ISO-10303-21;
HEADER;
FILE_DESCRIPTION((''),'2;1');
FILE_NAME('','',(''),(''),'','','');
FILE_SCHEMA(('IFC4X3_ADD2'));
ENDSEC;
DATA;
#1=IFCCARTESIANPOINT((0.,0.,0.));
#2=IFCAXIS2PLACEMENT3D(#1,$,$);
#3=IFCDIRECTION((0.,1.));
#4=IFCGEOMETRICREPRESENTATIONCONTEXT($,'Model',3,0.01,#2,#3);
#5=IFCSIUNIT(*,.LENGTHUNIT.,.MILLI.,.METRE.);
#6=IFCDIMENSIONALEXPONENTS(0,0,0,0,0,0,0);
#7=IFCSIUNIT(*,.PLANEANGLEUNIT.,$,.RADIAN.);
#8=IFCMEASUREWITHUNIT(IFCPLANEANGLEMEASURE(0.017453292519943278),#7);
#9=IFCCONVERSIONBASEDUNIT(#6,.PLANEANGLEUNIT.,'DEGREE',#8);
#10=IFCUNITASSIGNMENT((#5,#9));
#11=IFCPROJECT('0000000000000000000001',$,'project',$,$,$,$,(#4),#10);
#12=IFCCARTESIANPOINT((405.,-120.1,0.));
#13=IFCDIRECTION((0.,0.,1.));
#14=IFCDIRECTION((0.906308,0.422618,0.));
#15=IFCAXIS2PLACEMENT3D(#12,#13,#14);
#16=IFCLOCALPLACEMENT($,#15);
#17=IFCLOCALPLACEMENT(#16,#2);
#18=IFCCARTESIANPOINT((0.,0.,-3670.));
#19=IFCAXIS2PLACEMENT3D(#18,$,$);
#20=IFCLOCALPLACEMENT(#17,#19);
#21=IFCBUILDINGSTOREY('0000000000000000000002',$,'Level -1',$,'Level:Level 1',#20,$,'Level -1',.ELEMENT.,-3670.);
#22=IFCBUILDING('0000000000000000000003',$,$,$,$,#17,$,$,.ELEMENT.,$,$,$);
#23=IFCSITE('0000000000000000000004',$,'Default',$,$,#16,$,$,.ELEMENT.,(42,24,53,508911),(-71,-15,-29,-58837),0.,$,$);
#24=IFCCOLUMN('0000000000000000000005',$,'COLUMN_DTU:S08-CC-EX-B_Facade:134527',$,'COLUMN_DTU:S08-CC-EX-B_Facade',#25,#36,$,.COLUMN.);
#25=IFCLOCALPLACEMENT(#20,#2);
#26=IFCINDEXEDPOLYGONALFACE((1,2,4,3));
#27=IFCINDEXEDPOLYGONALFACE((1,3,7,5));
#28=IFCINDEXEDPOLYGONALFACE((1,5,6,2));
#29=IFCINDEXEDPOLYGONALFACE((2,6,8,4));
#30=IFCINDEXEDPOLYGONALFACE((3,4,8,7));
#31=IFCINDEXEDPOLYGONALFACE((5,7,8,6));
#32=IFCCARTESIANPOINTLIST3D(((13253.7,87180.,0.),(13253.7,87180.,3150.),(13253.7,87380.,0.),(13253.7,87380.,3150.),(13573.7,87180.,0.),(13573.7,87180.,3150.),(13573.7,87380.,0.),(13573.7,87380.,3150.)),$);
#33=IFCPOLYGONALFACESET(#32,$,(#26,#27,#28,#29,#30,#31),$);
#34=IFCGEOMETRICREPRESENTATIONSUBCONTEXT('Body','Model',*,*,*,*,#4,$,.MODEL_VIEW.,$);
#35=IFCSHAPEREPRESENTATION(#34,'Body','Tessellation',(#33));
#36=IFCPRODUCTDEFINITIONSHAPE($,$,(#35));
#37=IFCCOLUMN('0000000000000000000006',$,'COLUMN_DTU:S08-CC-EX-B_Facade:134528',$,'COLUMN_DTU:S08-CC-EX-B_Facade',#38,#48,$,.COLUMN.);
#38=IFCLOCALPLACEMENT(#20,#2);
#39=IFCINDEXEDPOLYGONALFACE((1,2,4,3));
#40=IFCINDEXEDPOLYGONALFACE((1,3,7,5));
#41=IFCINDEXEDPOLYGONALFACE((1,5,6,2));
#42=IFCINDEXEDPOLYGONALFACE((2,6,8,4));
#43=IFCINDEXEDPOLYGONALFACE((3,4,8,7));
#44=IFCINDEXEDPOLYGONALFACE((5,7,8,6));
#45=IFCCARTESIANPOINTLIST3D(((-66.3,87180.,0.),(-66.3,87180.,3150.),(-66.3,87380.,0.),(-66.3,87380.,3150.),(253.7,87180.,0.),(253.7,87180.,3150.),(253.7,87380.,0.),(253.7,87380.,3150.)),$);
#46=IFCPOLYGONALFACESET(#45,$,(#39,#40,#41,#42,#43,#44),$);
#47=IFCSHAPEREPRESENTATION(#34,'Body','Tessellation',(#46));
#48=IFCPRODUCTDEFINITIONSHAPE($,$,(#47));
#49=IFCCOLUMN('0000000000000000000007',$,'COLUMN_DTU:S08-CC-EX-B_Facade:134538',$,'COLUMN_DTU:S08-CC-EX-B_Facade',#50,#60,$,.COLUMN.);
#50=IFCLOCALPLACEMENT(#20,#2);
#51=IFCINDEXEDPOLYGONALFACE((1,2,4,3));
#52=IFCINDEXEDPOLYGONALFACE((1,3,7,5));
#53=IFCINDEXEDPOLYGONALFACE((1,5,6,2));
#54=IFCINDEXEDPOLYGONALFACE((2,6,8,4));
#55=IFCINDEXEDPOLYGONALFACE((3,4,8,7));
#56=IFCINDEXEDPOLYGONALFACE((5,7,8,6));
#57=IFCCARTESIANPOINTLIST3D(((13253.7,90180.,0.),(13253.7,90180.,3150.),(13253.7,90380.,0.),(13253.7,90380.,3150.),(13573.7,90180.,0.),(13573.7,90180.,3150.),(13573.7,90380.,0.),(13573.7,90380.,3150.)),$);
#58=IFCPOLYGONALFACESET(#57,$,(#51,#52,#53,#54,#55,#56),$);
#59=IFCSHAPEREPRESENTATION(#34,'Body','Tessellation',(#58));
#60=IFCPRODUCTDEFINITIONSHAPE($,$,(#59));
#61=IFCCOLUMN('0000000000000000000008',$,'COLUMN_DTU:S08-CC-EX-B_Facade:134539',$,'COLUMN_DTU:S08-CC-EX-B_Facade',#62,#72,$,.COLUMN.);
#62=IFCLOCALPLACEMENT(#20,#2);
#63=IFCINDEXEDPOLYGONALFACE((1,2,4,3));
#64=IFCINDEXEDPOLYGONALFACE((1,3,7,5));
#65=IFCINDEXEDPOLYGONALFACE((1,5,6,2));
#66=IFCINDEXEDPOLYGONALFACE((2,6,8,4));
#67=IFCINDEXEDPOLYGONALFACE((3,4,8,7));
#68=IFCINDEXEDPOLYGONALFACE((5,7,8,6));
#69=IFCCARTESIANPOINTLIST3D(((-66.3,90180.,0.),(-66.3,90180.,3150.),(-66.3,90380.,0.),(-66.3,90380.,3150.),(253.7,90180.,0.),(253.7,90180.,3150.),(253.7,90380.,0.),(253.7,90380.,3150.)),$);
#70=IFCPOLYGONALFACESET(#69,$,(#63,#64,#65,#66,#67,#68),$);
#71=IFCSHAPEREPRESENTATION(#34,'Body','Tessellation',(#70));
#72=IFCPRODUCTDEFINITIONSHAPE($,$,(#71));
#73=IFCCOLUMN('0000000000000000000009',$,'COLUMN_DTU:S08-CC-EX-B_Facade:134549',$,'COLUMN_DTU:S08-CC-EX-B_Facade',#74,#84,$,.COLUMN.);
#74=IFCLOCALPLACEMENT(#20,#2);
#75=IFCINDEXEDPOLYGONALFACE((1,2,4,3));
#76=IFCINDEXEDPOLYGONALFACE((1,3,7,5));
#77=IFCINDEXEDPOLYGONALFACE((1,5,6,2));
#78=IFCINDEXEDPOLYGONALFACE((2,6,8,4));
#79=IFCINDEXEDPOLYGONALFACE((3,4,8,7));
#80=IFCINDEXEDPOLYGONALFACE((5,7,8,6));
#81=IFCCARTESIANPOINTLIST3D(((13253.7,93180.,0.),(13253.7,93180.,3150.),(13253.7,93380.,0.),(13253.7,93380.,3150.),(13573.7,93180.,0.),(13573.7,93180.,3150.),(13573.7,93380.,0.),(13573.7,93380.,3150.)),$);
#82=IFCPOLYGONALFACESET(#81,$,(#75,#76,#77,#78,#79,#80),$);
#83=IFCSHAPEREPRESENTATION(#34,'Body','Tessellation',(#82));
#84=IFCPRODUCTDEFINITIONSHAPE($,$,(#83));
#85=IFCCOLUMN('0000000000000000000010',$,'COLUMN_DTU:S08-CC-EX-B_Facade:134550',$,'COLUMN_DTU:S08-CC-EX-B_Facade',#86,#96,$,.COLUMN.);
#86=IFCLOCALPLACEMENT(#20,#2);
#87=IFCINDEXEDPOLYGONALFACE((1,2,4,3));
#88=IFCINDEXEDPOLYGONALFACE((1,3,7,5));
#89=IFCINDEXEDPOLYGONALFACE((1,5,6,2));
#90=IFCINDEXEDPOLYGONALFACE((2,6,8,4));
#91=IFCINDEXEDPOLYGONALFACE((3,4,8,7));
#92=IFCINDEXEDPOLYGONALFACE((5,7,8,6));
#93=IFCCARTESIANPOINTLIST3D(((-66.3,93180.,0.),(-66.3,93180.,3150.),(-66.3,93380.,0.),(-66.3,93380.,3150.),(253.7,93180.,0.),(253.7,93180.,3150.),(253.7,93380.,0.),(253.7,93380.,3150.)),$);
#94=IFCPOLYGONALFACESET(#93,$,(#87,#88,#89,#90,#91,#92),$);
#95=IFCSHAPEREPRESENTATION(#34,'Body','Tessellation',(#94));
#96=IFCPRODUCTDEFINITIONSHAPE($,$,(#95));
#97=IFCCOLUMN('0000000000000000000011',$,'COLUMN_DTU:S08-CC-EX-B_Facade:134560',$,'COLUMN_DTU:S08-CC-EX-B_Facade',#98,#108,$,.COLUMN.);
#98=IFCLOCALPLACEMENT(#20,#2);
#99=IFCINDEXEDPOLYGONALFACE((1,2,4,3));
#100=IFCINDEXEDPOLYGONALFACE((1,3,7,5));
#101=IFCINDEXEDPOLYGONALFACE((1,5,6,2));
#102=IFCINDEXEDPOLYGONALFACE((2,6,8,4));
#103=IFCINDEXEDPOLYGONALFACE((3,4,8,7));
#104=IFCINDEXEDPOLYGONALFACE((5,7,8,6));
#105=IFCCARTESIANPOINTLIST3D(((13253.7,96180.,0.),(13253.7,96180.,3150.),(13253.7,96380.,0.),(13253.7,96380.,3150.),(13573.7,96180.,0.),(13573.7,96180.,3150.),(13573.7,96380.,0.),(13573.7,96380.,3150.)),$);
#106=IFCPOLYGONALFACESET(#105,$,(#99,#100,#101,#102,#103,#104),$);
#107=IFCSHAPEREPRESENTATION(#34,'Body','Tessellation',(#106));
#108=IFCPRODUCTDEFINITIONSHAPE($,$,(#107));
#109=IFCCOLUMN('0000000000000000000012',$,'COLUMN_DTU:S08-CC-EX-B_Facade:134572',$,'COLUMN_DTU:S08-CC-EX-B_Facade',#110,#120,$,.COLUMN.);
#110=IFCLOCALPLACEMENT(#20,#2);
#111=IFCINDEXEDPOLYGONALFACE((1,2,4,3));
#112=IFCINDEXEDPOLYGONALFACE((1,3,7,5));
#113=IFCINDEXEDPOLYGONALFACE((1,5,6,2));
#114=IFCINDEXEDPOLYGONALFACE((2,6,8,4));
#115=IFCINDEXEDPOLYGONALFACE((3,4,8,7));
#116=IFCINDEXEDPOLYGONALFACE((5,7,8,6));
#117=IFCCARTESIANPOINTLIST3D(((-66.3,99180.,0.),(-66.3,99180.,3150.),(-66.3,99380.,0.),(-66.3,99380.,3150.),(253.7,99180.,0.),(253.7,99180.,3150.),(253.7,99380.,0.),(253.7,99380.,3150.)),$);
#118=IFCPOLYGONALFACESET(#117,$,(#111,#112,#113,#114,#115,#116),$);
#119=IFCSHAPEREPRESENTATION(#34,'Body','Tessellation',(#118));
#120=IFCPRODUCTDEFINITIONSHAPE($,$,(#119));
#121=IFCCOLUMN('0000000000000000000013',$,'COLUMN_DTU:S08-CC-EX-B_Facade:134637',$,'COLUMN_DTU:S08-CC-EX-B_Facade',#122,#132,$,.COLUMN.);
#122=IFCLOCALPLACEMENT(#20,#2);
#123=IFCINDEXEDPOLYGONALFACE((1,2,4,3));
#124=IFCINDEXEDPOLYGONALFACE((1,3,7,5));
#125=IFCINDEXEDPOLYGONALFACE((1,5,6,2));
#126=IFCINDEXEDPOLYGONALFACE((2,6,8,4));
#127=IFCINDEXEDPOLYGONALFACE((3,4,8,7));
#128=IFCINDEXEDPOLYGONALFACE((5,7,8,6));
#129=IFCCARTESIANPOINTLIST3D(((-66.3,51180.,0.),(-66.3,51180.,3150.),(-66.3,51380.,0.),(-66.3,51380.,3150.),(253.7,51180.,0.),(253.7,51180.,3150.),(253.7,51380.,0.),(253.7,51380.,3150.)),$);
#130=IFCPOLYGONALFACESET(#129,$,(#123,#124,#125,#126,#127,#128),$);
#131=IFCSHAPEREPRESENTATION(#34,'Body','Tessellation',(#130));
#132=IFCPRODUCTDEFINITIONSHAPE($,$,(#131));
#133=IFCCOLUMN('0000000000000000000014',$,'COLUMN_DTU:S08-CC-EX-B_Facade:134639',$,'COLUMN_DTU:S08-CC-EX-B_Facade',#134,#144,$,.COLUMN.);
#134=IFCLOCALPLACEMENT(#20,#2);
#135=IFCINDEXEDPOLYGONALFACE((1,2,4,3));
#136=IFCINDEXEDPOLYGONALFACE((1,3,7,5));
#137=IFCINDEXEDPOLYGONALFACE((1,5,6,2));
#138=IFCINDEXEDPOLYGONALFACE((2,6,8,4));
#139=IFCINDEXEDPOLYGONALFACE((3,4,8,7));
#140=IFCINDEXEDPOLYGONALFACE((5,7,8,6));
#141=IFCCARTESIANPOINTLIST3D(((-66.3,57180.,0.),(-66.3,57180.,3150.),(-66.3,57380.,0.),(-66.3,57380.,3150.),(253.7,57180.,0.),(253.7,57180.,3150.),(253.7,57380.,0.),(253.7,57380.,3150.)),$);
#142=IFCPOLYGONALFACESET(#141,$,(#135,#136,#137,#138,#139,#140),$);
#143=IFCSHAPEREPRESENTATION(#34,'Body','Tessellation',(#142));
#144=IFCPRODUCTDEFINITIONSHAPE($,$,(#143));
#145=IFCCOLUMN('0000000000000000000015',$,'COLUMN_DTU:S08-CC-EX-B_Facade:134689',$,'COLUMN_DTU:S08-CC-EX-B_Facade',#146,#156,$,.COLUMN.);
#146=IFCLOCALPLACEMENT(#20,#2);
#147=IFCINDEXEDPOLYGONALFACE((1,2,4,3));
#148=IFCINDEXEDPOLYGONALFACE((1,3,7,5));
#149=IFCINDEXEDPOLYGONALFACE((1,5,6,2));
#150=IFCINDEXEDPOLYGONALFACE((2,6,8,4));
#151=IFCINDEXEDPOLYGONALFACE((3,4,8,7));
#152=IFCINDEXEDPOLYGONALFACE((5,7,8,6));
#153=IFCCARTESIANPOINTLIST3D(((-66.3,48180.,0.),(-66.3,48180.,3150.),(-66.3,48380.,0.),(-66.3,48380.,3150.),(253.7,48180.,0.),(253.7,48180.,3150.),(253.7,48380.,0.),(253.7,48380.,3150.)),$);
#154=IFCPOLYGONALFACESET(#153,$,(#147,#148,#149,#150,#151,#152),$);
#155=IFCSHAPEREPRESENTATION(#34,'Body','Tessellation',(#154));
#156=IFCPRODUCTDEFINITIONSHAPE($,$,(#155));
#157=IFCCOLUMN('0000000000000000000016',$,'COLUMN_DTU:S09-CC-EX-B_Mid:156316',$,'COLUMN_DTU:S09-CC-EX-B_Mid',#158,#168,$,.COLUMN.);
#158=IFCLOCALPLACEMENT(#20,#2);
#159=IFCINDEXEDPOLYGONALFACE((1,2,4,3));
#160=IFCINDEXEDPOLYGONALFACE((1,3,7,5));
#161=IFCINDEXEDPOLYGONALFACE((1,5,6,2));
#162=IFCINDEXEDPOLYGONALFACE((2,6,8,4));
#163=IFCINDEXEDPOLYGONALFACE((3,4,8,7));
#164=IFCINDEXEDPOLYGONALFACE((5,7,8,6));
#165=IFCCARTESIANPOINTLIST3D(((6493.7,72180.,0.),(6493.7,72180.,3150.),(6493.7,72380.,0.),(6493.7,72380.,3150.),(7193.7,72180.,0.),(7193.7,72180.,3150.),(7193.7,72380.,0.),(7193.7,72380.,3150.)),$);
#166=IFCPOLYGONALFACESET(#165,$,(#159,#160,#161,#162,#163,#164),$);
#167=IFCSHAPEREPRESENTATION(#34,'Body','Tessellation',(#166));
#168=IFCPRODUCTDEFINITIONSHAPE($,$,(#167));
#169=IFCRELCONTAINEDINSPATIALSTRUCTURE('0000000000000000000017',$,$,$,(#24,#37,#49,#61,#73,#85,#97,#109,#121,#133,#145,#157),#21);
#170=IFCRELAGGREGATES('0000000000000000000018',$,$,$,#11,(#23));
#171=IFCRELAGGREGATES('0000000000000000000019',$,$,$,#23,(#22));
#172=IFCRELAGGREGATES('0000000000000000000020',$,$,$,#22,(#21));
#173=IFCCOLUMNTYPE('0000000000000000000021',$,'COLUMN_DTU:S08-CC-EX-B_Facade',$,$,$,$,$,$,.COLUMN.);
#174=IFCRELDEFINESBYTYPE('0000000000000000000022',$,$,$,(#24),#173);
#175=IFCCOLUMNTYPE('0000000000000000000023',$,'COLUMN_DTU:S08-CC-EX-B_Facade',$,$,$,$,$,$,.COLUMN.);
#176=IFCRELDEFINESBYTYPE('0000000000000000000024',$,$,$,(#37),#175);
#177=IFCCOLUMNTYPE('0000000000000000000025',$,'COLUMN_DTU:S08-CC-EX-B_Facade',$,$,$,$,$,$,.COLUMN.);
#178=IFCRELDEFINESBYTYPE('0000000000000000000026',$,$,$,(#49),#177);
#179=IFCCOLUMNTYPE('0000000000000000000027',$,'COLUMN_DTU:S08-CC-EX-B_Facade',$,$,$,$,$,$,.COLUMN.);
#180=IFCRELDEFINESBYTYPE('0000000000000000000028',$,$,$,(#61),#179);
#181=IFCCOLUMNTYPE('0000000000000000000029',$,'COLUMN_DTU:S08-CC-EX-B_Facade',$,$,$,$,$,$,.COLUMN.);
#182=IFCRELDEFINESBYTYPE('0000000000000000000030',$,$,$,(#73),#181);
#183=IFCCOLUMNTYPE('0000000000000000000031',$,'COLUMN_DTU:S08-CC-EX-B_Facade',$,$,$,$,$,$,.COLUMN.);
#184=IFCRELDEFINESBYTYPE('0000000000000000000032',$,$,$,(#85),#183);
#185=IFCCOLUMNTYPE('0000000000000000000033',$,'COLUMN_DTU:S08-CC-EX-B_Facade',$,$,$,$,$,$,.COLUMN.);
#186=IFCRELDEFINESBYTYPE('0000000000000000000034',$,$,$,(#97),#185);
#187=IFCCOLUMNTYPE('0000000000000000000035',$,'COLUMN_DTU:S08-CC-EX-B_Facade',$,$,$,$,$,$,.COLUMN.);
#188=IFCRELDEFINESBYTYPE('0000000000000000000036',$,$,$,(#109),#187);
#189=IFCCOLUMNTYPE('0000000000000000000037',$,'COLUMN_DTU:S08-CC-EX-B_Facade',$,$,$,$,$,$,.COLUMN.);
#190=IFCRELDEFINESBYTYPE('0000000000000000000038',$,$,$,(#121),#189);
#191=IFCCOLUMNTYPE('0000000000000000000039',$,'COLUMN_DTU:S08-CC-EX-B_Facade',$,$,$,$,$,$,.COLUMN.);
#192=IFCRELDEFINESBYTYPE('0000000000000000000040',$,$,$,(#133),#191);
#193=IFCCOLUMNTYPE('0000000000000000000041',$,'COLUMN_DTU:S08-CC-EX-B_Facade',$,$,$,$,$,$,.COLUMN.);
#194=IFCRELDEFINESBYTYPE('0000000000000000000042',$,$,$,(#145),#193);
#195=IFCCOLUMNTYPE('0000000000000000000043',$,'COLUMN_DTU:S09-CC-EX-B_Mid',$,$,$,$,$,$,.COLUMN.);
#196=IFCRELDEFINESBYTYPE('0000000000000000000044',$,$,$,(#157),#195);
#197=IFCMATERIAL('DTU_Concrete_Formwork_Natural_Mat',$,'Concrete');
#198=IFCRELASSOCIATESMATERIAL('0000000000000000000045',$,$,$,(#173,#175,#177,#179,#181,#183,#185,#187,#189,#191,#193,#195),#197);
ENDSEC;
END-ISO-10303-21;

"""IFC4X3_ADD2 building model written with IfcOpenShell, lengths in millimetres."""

from ifc_helpers import new_model, entity, si_unit, converted_unit, direction, frame, frame_2d, origin, origin_2d_with_axis, place, context, subcontext, project, spatial, rectangle, extrude, source, transform, mapped, material, material_profile, profile_set, type_object, type_shapes, element, save


model = new_model("IFC4X3_ADD2")

# Units and contexts
model_context = context("Model", 3, precision=0.01, world=origin(), true_north=direction((0.0, 1.0)))
body_context = subcontext(model_context, "Body", "Model", "MODEL_VIEW")
ifc_project = project(units=[si_unit("LENGTHUNIT", "METRE", prefix="MILLI"), converted_unit("PLANEANGLEUNIT", "DEGREE", entity("IfcPlaneAngleMeasure", 0.017453292519943278), si_unit("PLANEANGLEUNIT", "RADIAN"), dimensions=[0, 0, 0, 0, 0, 0, 0])], contexts=[model_context])

# Site, building, storey
site_placement = place(None, frame((405.0, -120.1, 0.0), z_axis=(0.0, 0.0, 1.0), x_axis=(0.906308, 0.422618, 0.0)))
site = spatial("IfcSite", under=ifc_project, at=site_placement, Name="Default", CompositionType="ELEMENT", RefLatitude=(42, 24, 53, 508911), RefLongitude=(-71, -15, -29, -58837), RefElevation=0.0)
building_placement = place(site_placement, origin())
building = spatial("IfcBuilding", under=site, at=building_placement, CompositionType="ELEMENT")
storey_placement = place(building_placement, frame((0.0, 0.0, -3670.0)))
storey = spatial("IfcBuildingStorey", under=building, at=storey_placement, Name="Level -1", ObjectType="Level:Level 1", LongName="Level -1", CompositionType="ELEMENT", Elevation=-3670.0)

# Columns
ifc_material = material(Name="DTU_Concrete_Formwork_Natural_Mat", Category="Concrete")
ifc_material_profile_1 = material_profile(ifc_material, rectangle(XDim=200.0, YDim=700.0, at=frame_2d((0.0, 0.0), x_axis=(1.0, 0.0))), Name="S09-CC-EX-B_Mid")
ifc_profile_set_1 = profile_set([ifc_material_profile_1], Name="S09-CC-EX-B_Mid")
ifc_material_profile_2 = material_profile(ifc_material, rectangle(XDim=200.0, YDim=320.0, at=origin_2d_with_axis()), Name="S08-CC-EX-B_Facade")
ifc_profile_set_2 = profile_set([ifc_material_profile_2], Name="S08-CC-EX-B_Facade")
column_type_1 = type_object("IfcColumnType", Name="COLUMN_DTU:S08-CC-EX-B_Facade", PredefinedType="COLUMN", material=ifc_profile_set_2)
shared_shape_1 = source(origin(), body_context, "Body", "SweptSolid", [
    extrude(rectangle(XDim=200.0, YDim=320.0, at=frame_2d((0.0, 0.0), x_axis=(1.0, 0.0))), frame((13413.7, 87280.0, -3670.0), z_axis=(0.0, 0.0, 1.0), x_axis=(0.0, -1.0, 0.0)), (0.0, 0.0, 1.0), 3150.0),
])
type_shapes(column_type_1, [shared_shape_1])
column_1_placement = place(storey_placement, frame((0.0, 0.0, 3670.0)))
element("IfcColumn", 1, at=column_1_placement, inside=storey, type_object=column_type_1, Name="COLUMN_DTU:S08-CC-EX-B_Facade:134527", ObjectType="COLUMN_DTU:S08-CC-EX-B_Facade", PredefinedType="COLUMN", context=body_context, shape_type="MappedRepresentation", body=[
    mapped(shared_shape_1, transform((0.0, 0.0, 0.0), scale=1.0)),
])
column_type_2 = type_object("IfcColumnType", Name="COLUMN_DTU:S08-CC-EX-B_Facade", PredefinedType="COLUMN", material=ifc_profile_set_2)
shared_shape_2 = source(origin(), body_context, "Body", "SweptSolid", [
    extrude(rectangle(XDim=200.0, YDim=320.0, at=frame_2d((0.0, 0.0), x_axis=(1.0, 0.0))), frame((93.7, 87280.0, -3670.0), z_axis=(0.0, 0.0, 1.0), x_axis=(0.0, -1.0, 0.0)), (0.0, 0.0, 1.0), 3150.0),
])
type_shapes(column_type_2, [shared_shape_2])
column_2_placement = place(storey_placement, frame((0.0, 0.0, 3670.0)))
element("IfcColumn", 2, at=column_2_placement, inside=storey, type_object=column_type_2, Name="COLUMN_DTU:S08-CC-EX-B_Facade:134528", ObjectType="COLUMN_DTU:S08-CC-EX-B_Facade", PredefinedType="COLUMN", context=body_context, shape_type="MappedRepresentation", body=[
    mapped(shared_shape_2, transform((0.0, 0.0, 0.0), scale=1.0)),
])
column_type_3 = type_object("IfcColumnType", Name="COLUMN_DTU:S08-CC-EX-B_Facade", PredefinedType="COLUMN", material=ifc_profile_set_2)
shared_shape_3 = source(origin(), body_context, "Body", "SweptSolid", [
    extrude(rectangle(XDim=200.0, YDim=320.0, at=frame_2d((0.0, 0.0), x_axis=(1.0, 0.0))), frame((13413.7, 90280.0, -3670.0), z_axis=(0.0, 0.0, 1.0), x_axis=(0.0, -1.0, 0.0)), (0.0, 0.0, 1.0), 3150.0),
])
type_shapes(column_type_3, [shared_shape_3])
column_3_placement = place(storey_placement, frame((0.0, 0.0, 3670.0)))
element("IfcColumn", 3, at=column_3_placement, inside=storey, type_object=column_type_3, Name="COLUMN_DTU:S08-CC-EX-B_Facade:134538", ObjectType="COLUMN_DTU:S08-CC-EX-B_Facade", PredefinedType="COLUMN", context=body_context, shape_type="MappedRepresentation", body=[
    mapped(shared_shape_3, transform((0.0, 0.0, 0.0), scale=1.0)),
])
column_type_4 = type_object("IfcColumnType", Name="COLUMN_DTU:S08-CC-EX-B_Facade", PredefinedType="COLUMN", material=ifc_profile_set_2)
shared_shape_4 = source(origin(), body_context, "Body", "SweptSolid", [
    extrude(rectangle(XDim=200.0, YDim=320.0, at=frame_2d((0.0, 0.0), x_axis=(1.0, 0.0))), frame((93.7, 90280.0, -3670.0), z_axis=(0.0, 0.0, 1.0), x_axis=(0.0, -1.0, 0.0)), (0.0, 0.0, 1.0), 3150.0),
])
type_shapes(column_type_4, [shared_shape_4])
column_4_placement = place(storey_placement, frame((0.0, 0.0, 3670.0)))
element("IfcColumn", 4, at=column_4_placement, inside=storey, type_object=column_type_4, Name="COLUMN_DTU:S08-CC-EX-B_Facade:134539", ObjectType="COLUMN_DTU:S08-CC-EX-B_Facade", PredefinedType="COLUMN", context=body_context, shape_type="MappedRepresentation", body=[
    mapped(shared_shape_4, transform((0.0, 0.0, 0.0), scale=1.0)),
])
column_type_5 = type_object("IfcColumnType", Name="COLUMN_DTU:S08-CC-EX-B_Facade", PredefinedType="COLUMN", material=ifc_profile_set_2)
shared_shape_5 = source(origin(), body_context, "Body", "SweptSolid", [
    extrude(rectangle(XDim=200.0, YDim=320.0, at=frame_2d((0.0, 0.0), x_axis=(1.0, 0.0))), frame((13413.7, 93280.0, -3670.0), z_axis=(0.0, 0.0, 1.0), x_axis=(0.0, -1.0, 0.0)), (0.0, 0.0, 1.0), 3150.0),
])
type_shapes(column_type_5, [shared_shape_5])
column_5_placement = place(storey_placement, frame((0.0, 0.0, 3670.0)))
element("IfcColumn", 5, at=column_5_placement, inside=storey, type_object=column_type_5, Name="COLUMN_DTU:S08-CC-EX-B_Facade:134549", ObjectType="COLUMN_DTU:S08-CC-EX-B_Facade", PredefinedType="COLUMN", context=body_context, shape_type="MappedRepresentation", body=[
    mapped(shared_shape_5, transform((0.0, 0.0, 0.0), scale=1.0)),
])
column_type_6 = type_object("IfcColumnType", Name="COLUMN_DTU:S08-CC-EX-B_Facade", PredefinedType="COLUMN", material=ifc_profile_set_2)
shared_shape_6 = source(origin(), body_context, "Body", "SweptSolid", [
    extrude(rectangle(XDim=200.0, YDim=320.0, at=frame_2d((0.0, 0.0), x_axis=(1.0, 0.0))), frame((93.7, 93280.0, -3670.0), z_axis=(0.0, 0.0, 1.0), x_axis=(0.0, -1.0, 0.0)), (0.0, 0.0, 1.0), 3150.0),
])
type_shapes(column_type_6, [shared_shape_6])
column_6_placement = place(storey_placement, frame((0.0, 0.0, 3670.0)))
element("IfcColumn", 6, at=column_6_placement, inside=storey, type_object=column_type_6, Name="COLUMN_DTU:S08-CC-EX-B_Facade:134550", ObjectType="COLUMN_DTU:S08-CC-EX-B_Facade", PredefinedType="COLUMN", context=body_context, shape_type="MappedRepresentation", body=[
    mapped(shared_shape_6, transform((0.0, 0.0, 0.0), scale=1.0)),
])
column_type_7 = type_object("IfcColumnType", Name="COLUMN_DTU:S08-CC-EX-B_Facade", PredefinedType="COLUMN", material=ifc_profile_set_2)
shared_shape_7 = source(origin(), body_context, "Body", "SweptSolid", [
    extrude(rectangle(XDim=200.0, YDim=320.0, at=frame_2d((0.0, 0.0), x_axis=(1.0, 0.0))), frame((13413.7, 96280.0, -3670.0), z_axis=(0.0, 0.0, 1.0), x_axis=(0.0, -1.0, 0.0)), (0.0, 0.0, 1.0), 3150.0),
])
type_shapes(column_type_7, [shared_shape_7])
column_7_placement = place(storey_placement, frame((0.0, 0.0, 3670.0)))
element("IfcColumn", 7, at=column_7_placement, inside=storey, type_object=column_type_7, Name="COLUMN_DTU:S08-CC-EX-B_Facade:134560", ObjectType="COLUMN_DTU:S08-CC-EX-B_Facade", PredefinedType="COLUMN", context=body_context, shape_type="MappedRepresentation", body=[
    mapped(shared_shape_7, transform((0.0, 0.0, 0.0), scale=1.0)),
])
column_type_8 = type_object("IfcColumnType", Name="COLUMN_DTU:S08-CC-EX-B_Facade", PredefinedType="COLUMN", material=ifc_profile_set_2)
shared_shape_8 = source(origin(), body_context, "Body", "SweptSolid", [
    extrude(rectangle(XDim=200.0, YDim=320.0, at=frame_2d((0.0, 0.0), x_axis=(1.0, 0.0))), frame((93.7, 99280.0, -3670.0), z_axis=(0.0, 0.0, 1.0), x_axis=(0.0, -1.0, 0.0)), (0.0, 0.0, 1.0), 3150.0),
])
type_shapes(column_type_8, [shared_shape_8])
column_8_placement = place(storey_placement, frame((0.0, 0.0, 3670.0)))
element("IfcColumn", 8, at=column_8_placement, inside=storey, type_object=column_type_8, Name="COLUMN_DTU:S08-CC-EX-B_Facade:134572", ObjectType="COLUMN_DTU:S08-CC-EX-B_Facade", PredefinedType="COLUMN", context=body_context, shape_type="MappedRepresentation", body=[
    mapped(shared_shape_8, transform((0.0, 0.0, 0.0), scale=1.0)),
])
column_type_9 = type_object("IfcColumnType", Name="COLUMN_DTU:S08-CC-EX-B_Facade", PredefinedType="COLUMN", material=ifc_profile_set_2)
shared_shape_9 = source(origin(), body_context, "Body", "SweptSolid", [
    extrude(rectangle(XDim=200.0, YDim=320.0, at=frame_2d((0.0, 0.0), x_axis=(1.0, 0.0))), frame((93.7, 51280.0, -3670.0), z_axis=(0.0, 0.0, 1.0), x_axis=(0.0, -1.0, 0.0)), (0.0, 0.0, 1.0), 3150.0),
])
type_shapes(column_type_9, [shared_shape_9])
column_9_placement = place(storey_placement, frame((0.0, 0.0, 3670.0)))
element("IfcColumn", 9, at=column_9_placement, inside=storey, type_object=column_type_9, Name="COLUMN_DTU:S08-CC-EX-B_Facade:134637", ObjectType="COLUMN_DTU:S08-CC-EX-B_Facade", PredefinedType="COLUMN", context=body_context, shape_type="MappedRepresentation", body=[
    mapped(shared_shape_9, transform((0.0, 0.0, 0.0), scale=1.0)),
])
column_type_10 = type_object("IfcColumnType", Name="COLUMN_DTU:S08-CC-EX-B_Facade", PredefinedType="COLUMN", material=ifc_profile_set_2)
shared_shape_10 = source(origin(), body_context, "Body", "SweptSolid", [
    extrude(rectangle(XDim=200.0, YDim=320.0, at=frame_2d((0.0, 0.0), x_axis=(1.0, 0.0))), frame((93.7, 57280.0, -3670.0), z_axis=(0.0, 0.0, 1.0), x_axis=(0.0, -1.0, 0.0)), (0.0, 0.0, 1.0), 3150.0),
])
type_shapes(column_type_10, [shared_shape_10])
column_10_placement = place(storey_placement, frame((0.0, 0.0, 3670.0)))
element("IfcColumn", 10, at=column_10_placement, inside=storey, type_object=column_type_10, Name="COLUMN_DTU:S08-CC-EX-B_Facade:134639", ObjectType="COLUMN_DTU:S08-CC-EX-B_Facade", PredefinedType="COLUMN", context=body_context, shape_type="MappedRepresentation", body=[
    mapped(shared_shape_10, transform((0.0, 0.0, 0.0), scale=1.0)),
])
column_type_11 = type_object("IfcColumnType", Name="COLUMN_DTU:S08-CC-EX-B_Facade", PredefinedType="COLUMN", material=ifc_profile_set_2)
shared_shape_11 = source(origin(), body_context, "Body", "SweptSolid", [
    extrude(rectangle(XDim=200.0, YDim=320.0, at=frame_2d((0.0, 0.0), x_axis=(1.0, 0.0))), frame((93.7, 48280.0, -3670.0), z_axis=(0.0, 0.0, 1.0), x_axis=(0.0, -1.0, 0.0)), (0.0, 0.0, 1.0), 3150.0),
])
type_shapes(column_type_11, [shared_shape_11])
column_11_placement = place(storey_placement, frame((0.0, 0.0, 3670.0)))
element("IfcColumn", 11, at=column_11_placement, inside=storey, type_object=column_type_11, Name="COLUMN_DTU:S08-CC-EX-B_Facade:134689", ObjectType="COLUMN_DTU:S08-CC-EX-B_Facade", PredefinedType="COLUMN", context=body_context, shape_type="MappedRepresentation", body=[
    mapped(shared_shape_11, transform((0.0, 0.0, 0.0), scale=1.0)),
])
column_type_12 = type_object("IfcColumnType", Name="COLUMN_DTU:S09-CC-EX-B_Mid", PredefinedType="COLUMN", material=ifc_profile_set_1)
shared_shape_12 = source(origin(), body_context, "Body", "SweptSolid", [
    extrude(rectangle(XDim=200.0, YDim=700.0, at=frame_2d((0.0, 0.0), x_axis=(1.0, 0.0))), frame((6843.7, 72280.0, -3670.0), z_axis=(0.0, 0.0, 1.0), x_axis=(0.0, 1.0, 0.0)), (0.0, 0.0, 1.0), 3150.0),
])
type_shapes(column_type_12, [shared_shape_12])
column_12_placement = place(storey_placement, frame((0.0, 0.0, 3670.0)))
element("IfcColumn", 12, at=column_12_placement, inside=storey, type_object=column_type_12, Name="COLUMN_DTU:S09-CC-EX-B_Mid:156316", ObjectType="COLUMN_DTU:S09-CC-EX-B_Mid", PredefinedType="COLUMN", context=body_context, shape_type="MappedRepresentation", body=[
    mapped(shared_shape_12, transform((0.0, 0.0, 0.0), scale=1.0)),
])

save(model, "model.ifc")
